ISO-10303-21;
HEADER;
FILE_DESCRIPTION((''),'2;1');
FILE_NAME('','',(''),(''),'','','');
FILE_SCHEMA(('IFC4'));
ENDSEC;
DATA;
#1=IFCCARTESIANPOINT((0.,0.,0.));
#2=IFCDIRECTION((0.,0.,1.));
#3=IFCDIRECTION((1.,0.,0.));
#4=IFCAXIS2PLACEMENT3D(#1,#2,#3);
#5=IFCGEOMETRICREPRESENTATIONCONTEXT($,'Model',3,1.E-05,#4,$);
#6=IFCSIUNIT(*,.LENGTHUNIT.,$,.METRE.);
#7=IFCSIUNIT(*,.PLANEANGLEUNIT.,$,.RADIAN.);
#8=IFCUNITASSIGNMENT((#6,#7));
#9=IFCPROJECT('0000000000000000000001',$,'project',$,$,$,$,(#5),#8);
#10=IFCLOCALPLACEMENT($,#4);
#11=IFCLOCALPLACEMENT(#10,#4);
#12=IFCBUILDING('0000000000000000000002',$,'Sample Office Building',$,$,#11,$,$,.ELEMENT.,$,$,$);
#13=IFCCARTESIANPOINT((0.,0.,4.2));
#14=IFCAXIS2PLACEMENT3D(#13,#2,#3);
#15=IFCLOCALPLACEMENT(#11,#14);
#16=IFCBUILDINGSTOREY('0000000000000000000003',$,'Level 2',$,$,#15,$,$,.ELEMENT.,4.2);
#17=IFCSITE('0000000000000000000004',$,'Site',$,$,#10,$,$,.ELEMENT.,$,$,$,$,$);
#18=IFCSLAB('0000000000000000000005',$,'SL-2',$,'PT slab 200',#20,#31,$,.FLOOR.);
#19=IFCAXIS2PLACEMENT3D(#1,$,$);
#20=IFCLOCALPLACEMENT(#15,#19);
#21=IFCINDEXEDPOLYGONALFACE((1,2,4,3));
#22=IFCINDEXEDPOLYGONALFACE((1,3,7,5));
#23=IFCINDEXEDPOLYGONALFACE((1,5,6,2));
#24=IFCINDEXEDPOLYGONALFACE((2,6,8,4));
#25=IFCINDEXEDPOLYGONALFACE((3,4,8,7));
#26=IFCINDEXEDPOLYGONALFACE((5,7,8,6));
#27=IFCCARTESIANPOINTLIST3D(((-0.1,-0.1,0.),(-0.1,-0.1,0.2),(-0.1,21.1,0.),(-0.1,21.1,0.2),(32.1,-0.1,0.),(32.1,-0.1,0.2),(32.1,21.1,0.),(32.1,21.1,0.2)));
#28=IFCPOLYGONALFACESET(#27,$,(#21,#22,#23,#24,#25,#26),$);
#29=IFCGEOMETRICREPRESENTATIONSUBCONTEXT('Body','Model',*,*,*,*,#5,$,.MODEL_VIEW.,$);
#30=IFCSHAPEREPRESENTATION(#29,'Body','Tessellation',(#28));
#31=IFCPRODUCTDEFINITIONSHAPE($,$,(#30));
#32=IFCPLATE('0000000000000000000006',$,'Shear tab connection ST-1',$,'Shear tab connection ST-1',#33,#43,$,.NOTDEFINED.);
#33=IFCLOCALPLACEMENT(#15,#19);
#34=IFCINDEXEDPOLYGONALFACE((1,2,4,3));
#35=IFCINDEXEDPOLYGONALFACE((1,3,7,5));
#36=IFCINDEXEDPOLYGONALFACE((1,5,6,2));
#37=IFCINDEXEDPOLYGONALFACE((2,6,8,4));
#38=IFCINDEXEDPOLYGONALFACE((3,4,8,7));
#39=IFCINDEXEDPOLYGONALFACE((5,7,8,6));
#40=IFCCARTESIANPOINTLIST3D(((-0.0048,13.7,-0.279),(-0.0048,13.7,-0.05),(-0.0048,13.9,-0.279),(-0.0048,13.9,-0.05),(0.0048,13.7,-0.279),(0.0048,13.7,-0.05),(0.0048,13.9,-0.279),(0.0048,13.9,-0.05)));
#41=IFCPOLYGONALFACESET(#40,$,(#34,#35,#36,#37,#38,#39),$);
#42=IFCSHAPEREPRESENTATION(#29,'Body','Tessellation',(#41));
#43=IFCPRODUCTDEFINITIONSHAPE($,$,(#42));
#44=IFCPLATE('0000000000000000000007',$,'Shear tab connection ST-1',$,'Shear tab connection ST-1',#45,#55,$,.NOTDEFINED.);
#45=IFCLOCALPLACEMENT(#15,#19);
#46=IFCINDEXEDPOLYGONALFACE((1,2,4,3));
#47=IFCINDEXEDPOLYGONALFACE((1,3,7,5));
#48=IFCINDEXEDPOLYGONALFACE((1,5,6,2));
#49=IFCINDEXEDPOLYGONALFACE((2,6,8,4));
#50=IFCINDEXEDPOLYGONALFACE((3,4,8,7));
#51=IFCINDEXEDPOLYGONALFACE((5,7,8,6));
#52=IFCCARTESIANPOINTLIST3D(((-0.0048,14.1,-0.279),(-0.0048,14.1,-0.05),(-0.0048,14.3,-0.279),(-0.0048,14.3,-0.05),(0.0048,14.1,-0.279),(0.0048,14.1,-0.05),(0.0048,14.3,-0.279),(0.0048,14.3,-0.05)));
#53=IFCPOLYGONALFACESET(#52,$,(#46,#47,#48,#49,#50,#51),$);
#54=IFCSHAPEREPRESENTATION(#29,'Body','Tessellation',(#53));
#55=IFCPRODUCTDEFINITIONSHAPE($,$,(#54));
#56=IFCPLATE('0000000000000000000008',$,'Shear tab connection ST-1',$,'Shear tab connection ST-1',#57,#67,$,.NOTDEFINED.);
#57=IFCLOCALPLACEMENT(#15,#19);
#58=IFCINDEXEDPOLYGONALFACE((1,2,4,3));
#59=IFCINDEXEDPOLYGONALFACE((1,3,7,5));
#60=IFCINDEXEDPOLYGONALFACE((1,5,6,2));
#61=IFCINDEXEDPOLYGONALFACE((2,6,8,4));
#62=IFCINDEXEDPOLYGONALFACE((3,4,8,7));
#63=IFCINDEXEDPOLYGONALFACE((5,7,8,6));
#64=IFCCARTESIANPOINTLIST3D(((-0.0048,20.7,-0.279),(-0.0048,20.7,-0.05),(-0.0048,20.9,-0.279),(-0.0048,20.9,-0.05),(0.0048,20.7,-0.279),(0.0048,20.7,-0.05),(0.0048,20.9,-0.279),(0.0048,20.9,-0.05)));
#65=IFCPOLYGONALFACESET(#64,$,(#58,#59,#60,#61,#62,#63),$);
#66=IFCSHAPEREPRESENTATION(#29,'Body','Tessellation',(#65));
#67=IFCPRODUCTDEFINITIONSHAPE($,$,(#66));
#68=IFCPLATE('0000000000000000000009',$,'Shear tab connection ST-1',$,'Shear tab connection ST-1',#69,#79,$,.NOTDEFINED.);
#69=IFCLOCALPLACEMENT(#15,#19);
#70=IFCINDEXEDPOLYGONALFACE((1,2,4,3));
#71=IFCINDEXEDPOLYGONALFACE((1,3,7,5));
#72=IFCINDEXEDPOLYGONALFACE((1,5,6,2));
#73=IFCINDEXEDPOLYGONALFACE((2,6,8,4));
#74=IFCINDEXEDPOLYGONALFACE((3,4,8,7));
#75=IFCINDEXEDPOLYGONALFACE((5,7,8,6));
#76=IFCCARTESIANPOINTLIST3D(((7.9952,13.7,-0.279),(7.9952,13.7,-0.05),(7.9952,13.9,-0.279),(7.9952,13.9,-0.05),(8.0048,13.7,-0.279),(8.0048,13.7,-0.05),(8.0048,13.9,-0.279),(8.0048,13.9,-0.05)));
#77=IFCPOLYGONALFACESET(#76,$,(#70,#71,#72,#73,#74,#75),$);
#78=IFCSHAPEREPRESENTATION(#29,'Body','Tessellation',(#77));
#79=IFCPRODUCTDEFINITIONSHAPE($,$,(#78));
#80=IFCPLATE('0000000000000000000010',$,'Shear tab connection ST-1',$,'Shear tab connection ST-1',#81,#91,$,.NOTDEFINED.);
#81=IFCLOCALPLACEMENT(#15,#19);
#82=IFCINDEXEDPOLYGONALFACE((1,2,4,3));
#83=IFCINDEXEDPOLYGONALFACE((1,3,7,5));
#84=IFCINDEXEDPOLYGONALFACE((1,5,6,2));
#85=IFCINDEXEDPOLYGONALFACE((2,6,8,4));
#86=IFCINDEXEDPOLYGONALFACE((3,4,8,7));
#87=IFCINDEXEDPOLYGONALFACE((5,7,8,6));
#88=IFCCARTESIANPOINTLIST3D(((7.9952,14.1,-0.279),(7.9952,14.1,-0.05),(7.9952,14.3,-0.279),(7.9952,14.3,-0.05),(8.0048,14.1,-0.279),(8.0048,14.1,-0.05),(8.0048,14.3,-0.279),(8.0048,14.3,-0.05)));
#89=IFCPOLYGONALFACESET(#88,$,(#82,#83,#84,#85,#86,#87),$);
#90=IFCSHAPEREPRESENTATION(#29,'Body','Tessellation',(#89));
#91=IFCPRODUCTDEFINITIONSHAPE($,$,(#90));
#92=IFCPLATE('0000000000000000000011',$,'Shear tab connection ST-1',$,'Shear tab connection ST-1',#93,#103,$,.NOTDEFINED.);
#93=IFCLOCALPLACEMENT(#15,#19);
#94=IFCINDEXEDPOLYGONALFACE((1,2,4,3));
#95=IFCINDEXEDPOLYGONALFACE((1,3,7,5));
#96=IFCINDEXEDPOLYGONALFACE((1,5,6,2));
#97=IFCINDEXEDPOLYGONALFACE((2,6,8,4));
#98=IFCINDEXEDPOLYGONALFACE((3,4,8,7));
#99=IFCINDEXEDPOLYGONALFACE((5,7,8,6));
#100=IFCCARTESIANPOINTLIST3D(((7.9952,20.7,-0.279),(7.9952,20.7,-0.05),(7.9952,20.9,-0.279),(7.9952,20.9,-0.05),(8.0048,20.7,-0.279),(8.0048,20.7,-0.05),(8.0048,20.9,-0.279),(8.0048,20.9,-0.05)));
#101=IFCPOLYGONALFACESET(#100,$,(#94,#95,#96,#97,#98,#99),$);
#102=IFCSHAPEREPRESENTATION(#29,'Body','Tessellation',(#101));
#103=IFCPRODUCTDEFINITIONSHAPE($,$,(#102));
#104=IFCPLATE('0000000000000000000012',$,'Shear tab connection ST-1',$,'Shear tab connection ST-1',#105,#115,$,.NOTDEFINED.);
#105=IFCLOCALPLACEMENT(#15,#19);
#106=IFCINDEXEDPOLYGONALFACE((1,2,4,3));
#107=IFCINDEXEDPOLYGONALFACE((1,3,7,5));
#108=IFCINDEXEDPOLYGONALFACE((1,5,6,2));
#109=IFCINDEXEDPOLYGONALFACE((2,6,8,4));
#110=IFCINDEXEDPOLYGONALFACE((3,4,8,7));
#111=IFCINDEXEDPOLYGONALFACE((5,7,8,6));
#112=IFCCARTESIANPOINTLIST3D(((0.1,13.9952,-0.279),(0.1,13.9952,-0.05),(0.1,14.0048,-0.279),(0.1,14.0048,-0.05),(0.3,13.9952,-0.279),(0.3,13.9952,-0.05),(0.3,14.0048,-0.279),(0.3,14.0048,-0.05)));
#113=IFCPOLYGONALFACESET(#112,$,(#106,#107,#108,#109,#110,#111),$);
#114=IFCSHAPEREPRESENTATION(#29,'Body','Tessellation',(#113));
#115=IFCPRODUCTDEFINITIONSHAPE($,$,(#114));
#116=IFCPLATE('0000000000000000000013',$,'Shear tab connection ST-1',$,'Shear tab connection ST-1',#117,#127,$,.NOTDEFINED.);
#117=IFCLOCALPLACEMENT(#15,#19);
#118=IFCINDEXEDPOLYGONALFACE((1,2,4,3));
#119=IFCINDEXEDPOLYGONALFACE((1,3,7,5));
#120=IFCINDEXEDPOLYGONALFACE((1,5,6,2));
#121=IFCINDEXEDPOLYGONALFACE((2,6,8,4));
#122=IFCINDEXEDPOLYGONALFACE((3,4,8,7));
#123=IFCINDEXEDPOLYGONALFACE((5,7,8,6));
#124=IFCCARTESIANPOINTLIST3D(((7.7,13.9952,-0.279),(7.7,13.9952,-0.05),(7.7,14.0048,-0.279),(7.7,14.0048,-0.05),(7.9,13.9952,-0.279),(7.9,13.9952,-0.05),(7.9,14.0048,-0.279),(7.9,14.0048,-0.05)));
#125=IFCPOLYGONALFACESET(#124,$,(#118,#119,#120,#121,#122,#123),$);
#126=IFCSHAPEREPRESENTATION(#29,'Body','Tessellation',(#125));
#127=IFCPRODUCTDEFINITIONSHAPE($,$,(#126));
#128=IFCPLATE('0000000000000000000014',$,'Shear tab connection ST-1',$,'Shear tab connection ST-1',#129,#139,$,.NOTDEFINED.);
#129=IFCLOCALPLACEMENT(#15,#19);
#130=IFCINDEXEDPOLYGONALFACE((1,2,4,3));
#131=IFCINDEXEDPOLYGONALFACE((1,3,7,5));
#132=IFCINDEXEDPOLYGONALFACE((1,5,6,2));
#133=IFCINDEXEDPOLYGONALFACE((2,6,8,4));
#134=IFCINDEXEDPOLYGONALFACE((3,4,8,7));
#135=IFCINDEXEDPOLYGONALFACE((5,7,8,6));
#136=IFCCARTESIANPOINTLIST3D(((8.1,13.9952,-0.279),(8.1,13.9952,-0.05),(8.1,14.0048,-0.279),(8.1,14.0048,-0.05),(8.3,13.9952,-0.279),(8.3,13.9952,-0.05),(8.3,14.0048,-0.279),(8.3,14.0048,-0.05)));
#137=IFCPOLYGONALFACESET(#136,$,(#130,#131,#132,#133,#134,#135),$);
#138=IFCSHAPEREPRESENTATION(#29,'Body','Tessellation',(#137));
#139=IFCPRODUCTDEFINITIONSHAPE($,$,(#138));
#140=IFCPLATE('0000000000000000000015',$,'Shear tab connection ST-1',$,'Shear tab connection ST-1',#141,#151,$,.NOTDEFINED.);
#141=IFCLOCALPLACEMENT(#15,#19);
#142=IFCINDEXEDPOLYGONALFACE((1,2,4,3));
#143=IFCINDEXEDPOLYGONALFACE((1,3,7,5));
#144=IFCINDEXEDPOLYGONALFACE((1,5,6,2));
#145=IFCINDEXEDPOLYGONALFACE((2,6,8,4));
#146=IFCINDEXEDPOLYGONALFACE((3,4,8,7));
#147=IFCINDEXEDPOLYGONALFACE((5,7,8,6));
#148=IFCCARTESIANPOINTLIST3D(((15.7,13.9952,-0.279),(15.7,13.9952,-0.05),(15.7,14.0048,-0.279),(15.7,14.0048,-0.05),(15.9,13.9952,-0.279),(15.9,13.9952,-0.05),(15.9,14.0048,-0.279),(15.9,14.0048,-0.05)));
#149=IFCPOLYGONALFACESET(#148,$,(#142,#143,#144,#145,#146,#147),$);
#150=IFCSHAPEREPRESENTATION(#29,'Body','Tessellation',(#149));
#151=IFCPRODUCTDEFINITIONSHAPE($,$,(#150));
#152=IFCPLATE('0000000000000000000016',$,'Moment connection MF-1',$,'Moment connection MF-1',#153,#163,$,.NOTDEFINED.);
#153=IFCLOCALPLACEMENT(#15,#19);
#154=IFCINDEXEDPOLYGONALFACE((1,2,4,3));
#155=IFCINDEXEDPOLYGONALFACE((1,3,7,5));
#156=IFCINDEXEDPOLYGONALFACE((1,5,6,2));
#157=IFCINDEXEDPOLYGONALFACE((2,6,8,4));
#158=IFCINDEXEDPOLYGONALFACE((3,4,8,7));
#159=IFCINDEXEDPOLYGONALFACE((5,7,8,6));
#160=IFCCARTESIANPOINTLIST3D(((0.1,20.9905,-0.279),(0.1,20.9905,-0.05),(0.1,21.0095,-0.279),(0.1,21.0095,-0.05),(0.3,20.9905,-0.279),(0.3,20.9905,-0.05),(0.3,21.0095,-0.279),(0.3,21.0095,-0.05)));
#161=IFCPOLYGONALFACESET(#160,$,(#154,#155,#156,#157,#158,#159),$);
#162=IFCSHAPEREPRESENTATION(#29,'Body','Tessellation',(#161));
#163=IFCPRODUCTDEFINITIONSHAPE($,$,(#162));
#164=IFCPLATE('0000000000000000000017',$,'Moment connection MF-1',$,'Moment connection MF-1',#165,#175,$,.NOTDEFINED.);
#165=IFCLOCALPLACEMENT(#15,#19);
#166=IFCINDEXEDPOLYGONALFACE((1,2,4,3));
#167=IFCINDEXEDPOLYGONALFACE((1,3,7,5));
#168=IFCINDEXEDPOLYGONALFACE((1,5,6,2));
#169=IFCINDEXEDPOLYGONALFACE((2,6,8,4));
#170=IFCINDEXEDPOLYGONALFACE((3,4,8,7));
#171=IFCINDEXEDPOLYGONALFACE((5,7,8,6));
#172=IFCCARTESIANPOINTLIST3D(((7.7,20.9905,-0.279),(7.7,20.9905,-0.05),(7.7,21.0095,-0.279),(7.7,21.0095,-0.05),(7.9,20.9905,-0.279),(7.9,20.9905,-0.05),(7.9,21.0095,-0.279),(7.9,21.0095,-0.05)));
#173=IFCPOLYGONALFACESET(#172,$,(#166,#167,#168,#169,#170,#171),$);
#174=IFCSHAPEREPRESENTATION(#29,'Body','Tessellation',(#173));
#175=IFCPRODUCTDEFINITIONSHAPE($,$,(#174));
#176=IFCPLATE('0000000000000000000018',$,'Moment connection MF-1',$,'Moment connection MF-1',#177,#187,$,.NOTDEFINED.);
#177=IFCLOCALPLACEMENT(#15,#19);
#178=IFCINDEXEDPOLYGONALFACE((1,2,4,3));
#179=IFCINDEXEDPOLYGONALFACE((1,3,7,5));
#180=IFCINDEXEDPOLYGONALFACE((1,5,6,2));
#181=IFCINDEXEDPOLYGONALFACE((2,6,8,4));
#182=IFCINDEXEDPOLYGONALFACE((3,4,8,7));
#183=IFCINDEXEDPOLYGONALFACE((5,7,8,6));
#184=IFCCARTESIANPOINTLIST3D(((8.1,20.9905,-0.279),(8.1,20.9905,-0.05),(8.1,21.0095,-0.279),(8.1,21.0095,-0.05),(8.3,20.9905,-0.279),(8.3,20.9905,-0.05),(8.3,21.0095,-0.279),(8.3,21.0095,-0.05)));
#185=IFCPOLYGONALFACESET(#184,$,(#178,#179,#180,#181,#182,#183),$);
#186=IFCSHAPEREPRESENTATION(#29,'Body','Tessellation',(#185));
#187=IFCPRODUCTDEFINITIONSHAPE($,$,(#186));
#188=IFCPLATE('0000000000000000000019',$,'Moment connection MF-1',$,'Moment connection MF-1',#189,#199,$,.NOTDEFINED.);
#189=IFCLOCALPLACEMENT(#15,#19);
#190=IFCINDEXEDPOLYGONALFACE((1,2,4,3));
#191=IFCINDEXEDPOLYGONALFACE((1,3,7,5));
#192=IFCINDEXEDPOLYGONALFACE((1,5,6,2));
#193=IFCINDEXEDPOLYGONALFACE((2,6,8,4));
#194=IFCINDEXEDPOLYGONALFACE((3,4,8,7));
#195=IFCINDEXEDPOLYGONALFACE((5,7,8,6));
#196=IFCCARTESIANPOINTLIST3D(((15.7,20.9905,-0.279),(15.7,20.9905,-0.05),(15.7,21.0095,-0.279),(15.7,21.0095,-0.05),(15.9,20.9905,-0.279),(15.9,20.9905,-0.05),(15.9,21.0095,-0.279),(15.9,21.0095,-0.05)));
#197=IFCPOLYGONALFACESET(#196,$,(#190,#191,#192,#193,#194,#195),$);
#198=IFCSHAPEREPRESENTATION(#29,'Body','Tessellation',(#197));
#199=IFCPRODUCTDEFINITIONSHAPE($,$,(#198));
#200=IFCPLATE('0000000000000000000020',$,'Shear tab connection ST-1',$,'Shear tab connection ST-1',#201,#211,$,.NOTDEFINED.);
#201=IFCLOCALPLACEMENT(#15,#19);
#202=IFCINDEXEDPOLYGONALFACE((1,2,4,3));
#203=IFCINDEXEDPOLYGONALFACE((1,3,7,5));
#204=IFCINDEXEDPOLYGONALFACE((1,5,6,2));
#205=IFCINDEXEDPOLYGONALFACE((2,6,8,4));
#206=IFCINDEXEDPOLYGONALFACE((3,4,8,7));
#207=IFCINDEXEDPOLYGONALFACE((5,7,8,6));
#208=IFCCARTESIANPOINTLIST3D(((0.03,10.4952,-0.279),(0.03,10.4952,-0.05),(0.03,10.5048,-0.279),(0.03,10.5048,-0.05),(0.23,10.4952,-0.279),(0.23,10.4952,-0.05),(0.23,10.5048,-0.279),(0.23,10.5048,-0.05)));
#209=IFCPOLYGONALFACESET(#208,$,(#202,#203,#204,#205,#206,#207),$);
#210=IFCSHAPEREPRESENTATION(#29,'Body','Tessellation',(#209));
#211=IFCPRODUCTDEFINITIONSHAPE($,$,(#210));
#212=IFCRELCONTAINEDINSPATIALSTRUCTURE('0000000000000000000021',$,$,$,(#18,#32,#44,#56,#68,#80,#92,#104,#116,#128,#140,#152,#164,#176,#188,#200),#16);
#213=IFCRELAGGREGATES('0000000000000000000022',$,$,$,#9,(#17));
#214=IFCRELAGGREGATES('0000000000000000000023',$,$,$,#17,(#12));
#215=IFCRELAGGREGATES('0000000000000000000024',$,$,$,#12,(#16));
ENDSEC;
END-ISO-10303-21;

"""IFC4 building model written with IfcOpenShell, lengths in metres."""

from ifc_helpers import new_model, si_unit, frame, origin_with_axes, place, context, subcontext, project, spatial, rectangle, extrude, element, save


model = new_model("IFC4")

# Units and contexts
model_context = context("Model", 3, precision=1e-05, world=origin_with_axes())
body_context = subcontext(model_context, "Body", "Model", "MODEL_VIEW")
ifc_project = project(units=[si_unit("LENGTHUNIT", "METRE"), si_unit("PLANEANGLEUNIT", "RADIAN")], contexts=[model_context])

# Site, building, storey
site_placement = place(None, origin_with_axes())
site = spatial("IfcSite", under=ifc_project, at=site_placement, Name="Site", CompositionType="ELEMENT")
building_placement = place(site_placement, origin_with_axes())
building = spatial("IfcBuilding", under=site, at=building_placement, Name="Sample Office Building", CompositionType="ELEMENT")
storey_placement = place(building_placement, frame((0.0, 0.0, 4.2), z_axis=(0.0, 0.0, 1.0), x_axis=(1.0, 0.0, 0.0)))
storey = spatial("IfcBuildingStorey", under=building, at=storey_placement, Name="Level 2", CompositionType="ELEMENT", Elevation=4.2)

# Slab
slab_placement = place(None, frame((16.0, 10.5, 4.2), z_axis=(0.0, 0.0, 1.0), x_axis=(1.0, 0.0, 0.0)))
element("IfcSlab", 1, at=slab_placement, inside=storey, Name="SL-2", ObjectType="PT slab 200", PredefinedType="FLOOR", context=body_context, shape_type="SweptSolid", body=[
    extrude(rectangle(XDim=32.2, YDim=21.2), None, (0.0, 0.0, 1.0), 0.2),
])

# Plates
for number, where, z_axis, x_axis, name in (
    (2, (0.0, 13.8, 3.921), (0.0, 0.0, 1.0), (1.0, 0.0, 0.0), "Shear tab connection ST-1"),
    (3, (0.0, 14.2, 3.921), (0.0, 0.0, 1.0), (1.0, 0.0, 0.0), "Shear tab connection ST-1"),
):
    element("IfcPlate", number, at=place(None, frame(where, z_axis=z_axis, x_axis=x_axis)), inside=storey, Name=name, ObjectType="Shear tab connection ST-1", PredefinedType="NOTDEFINED", context=body_context, shape_type="SweptSolid", body=[
        extrude(rectangle(XDim=0.0095, YDim=0.2), None, (0.0, 0.0, 1.0), 0.229),
    ])
plate_1_placement = place(None, frame((0.0, 20.8, 3.921), z_axis=(0.0, 0.0, 1.0), x_axis=(1.0, 0.0, 0.0)))
element("IfcPlate", 4, at=plate_1_placement, inside=storey, Name="Shear tab connection ST-1", ObjectType="Shear tab connection ST-1", PredefinedType="NOTDEFINED", context=body_context, shape_type="SweptSolid", body=[
    extrude(rectangle(XDim=0.0095, YDim=0.2), None, (0.0, 0.0, 1.0), 0.229),
])
for number, where, z_axis, x_axis, name in (
    (5, (8.0, 13.8, 3.921), (0.0, 0.0, 1.0), (1.0, 0.0, 0.0), "Shear tab connection ST-1"),
    (6, (8.0, 14.2, 3.921), (0.0, 0.0, 1.0), (1.0, 0.0, 0.0), "Shear tab connection ST-1"),
):
    element("IfcPlate", number, at=place(None, frame(where, z_axis=z_axis, x_axis=x_axis)), inside=storey, Name=name, ObjectType="Shear tab connection ST-1", PredefinedType="NOTDEFINED", context=body_context, shape_type="SweptSolid", body=[
        extrude(rectangle(XDim=0.0095, YDim=0.2), None, (0.0, 0.0, 1.0), 0.229),
    ])
plate_2_placement = place(None, frame((8.0, 20.8, 3.921), z_axis=(0.0, 0.0, 1.0), x_axis=(1.0, 0.0, 0.0)))
element("IfcPlate", 7, at=plate_2_placement, inside=storey, Name="Shear tab connection ST-1", ObjectType="Shear tab connection ST-1", PredefinedType="NOTDEFINED", context=body_context, shape_type="SweptSolid", body=[
    extrude(rectangle(XDim=0.0095, YDim=0.2), None, (0.0, 0.0, 1.0), 0.229),
])
plate_3_placement = place(None, frame((0.2, 14.0, 3.921), z_axis=(0.0, 0.0, 1.0), x_axis=(1.0, 0.0, 0.0)))
element("IfcPlate", 8, at=plate_3_placement, inside=storey, Name="Shear tab connection ST-1", ObjectType="Shear tab connection ST-1", PredefinedType="NOTDEFINED", context=body_context, shape_type="SweptSolid", body=[
    extrude(rectangle(XDim=0.2, YDim=0.0095), None, (0.0, 0.0, 1.0), 0.229),
])
plate_4_placement = place(None, frame((7.8, 14.0, 3.921), z_axis=(0.0, 0.0, 1.0), x_axis=(1.0, 0.0, 0.0)))
element("IfcPlate", 9, at=plate_4_placement, inside=storey, Name="Shear tab connection ST-1", ObjectType="Shear tab connection ST-1", PredefinedType="NOTDEFINED", context=body_context, shape_type="SweptSolid", body=[
    extrude(rectangle(XDim=0.2, YDim=0.0095), None, (0.0, 0.0, 1.0), 0.229),
])
for number, where, z_axis, x_axis, name in (
    (10, (8.2, 14.0, 3.921), (0.0, 0.0, 1.0), (1.0, 0.0, 0.0), "Shear tab connection ST-1"),
    (11, (15.8, 14.0, 3.921), (0.0, 0.0, 1.0), (1.0, 0.0, 0.0), "Shear tab connection ST-1"),
):
    element("IfcPlate", number, at=place(None, frame(where, z_axis=z_axis, x_axis=x_axis)), inside=storey, Name=name, ObjectType="Shear tab connection ST-1", PredefinedType="NOTDEFINED", context=body_context, shape_type="SweptSolid", body=[
        extrude(rectangle(XDim=0.2, YDim=0.0095), None, (0.0, 0.0, 1.0), 0.229),
    ])
plate_5_placement = place(None, frame((0.2, 21.0, 3.921), z_axis=(0.0, 0.0, 1.0), x_axis=(1.0, 0.0, 0.0)))
element("IfcPlate", 12, at=plate_5_placement, inside=storey, Name="Moment connection MF-1", ObjectType="Moment connection MF-1", PredefinedType="NOTDEFINED", context=body_context, shape_type="SweptSolid", body=[
    extrude(rectangle(XDim=0.2, YDim=0.019), None, (0.0, 0.0, 1.0), 0.229),
])
plate_6_placement = place(None, frame((7.8, 21.0, 3.921), z_axis=(0.0, 0.0, 1.0), x_axis=(1.0, 0.0, 0.0)))
element("IfcPlate", 13, at=plate_6_placement, inside=storey, Name="Moment connection MF-1", ObjectType="Moment connection MF-1", PredefinedType="NOTDEFINED", context=body_context, shape_type="SweptSolid", body=[
    extrude(rectangle(XDim=0.2, YDim=0.019), None, (0.0, 0.0, 1.0), 0.229),
])
for number, where, z_axis, x_axis, name in (
    (14, (8.2, 21.0, 3.921), (0.0, 0.0, 1.0), (1.0, 0.0, 0.0), "Moment connection MF-1"),
    (15, (15.8, 21.0, 3.921), (0.0, 0.0, 1.0), (1.0, 0.0, 0.0), "Moment connection MF-1"),
):
    element("IfcPlate", number, at=place(None, frame(where, z_axis=z_axis, x_axis=x_axis)), inside=storey, Name=name, ObjectType="Moment connection MF-1", PredefinedType="NOTDEFINED", context=body_context, shape_type="SweptSolid", body=[
        extrude(rectangle(XDim=0.2, YDim=0.019), None, (0.0, 0.0, 1.0), 0.229),
    ])
plate_7_placement = place(None, frame((0.13, 10.5, 3.921), z_axis=(0.0, 0.0, 1.0), x_axis=(1.0, 0.0, 0.0)))
element("IfcPlate", 16, at=plate_7_placement, inside=storey, Name="Shear tab connection ST-1", ObjectType="Shear tab connection ST-1", PredefinedType="NOTDEFINED", context=body_context, shape_type="SweptSolid", body=[
    extrude(rectangle(XDim=0.2, YDim=0.0095), None, (0.0, 0.0, 1.0), 0.229),
])

save(model, "model.ifc")
